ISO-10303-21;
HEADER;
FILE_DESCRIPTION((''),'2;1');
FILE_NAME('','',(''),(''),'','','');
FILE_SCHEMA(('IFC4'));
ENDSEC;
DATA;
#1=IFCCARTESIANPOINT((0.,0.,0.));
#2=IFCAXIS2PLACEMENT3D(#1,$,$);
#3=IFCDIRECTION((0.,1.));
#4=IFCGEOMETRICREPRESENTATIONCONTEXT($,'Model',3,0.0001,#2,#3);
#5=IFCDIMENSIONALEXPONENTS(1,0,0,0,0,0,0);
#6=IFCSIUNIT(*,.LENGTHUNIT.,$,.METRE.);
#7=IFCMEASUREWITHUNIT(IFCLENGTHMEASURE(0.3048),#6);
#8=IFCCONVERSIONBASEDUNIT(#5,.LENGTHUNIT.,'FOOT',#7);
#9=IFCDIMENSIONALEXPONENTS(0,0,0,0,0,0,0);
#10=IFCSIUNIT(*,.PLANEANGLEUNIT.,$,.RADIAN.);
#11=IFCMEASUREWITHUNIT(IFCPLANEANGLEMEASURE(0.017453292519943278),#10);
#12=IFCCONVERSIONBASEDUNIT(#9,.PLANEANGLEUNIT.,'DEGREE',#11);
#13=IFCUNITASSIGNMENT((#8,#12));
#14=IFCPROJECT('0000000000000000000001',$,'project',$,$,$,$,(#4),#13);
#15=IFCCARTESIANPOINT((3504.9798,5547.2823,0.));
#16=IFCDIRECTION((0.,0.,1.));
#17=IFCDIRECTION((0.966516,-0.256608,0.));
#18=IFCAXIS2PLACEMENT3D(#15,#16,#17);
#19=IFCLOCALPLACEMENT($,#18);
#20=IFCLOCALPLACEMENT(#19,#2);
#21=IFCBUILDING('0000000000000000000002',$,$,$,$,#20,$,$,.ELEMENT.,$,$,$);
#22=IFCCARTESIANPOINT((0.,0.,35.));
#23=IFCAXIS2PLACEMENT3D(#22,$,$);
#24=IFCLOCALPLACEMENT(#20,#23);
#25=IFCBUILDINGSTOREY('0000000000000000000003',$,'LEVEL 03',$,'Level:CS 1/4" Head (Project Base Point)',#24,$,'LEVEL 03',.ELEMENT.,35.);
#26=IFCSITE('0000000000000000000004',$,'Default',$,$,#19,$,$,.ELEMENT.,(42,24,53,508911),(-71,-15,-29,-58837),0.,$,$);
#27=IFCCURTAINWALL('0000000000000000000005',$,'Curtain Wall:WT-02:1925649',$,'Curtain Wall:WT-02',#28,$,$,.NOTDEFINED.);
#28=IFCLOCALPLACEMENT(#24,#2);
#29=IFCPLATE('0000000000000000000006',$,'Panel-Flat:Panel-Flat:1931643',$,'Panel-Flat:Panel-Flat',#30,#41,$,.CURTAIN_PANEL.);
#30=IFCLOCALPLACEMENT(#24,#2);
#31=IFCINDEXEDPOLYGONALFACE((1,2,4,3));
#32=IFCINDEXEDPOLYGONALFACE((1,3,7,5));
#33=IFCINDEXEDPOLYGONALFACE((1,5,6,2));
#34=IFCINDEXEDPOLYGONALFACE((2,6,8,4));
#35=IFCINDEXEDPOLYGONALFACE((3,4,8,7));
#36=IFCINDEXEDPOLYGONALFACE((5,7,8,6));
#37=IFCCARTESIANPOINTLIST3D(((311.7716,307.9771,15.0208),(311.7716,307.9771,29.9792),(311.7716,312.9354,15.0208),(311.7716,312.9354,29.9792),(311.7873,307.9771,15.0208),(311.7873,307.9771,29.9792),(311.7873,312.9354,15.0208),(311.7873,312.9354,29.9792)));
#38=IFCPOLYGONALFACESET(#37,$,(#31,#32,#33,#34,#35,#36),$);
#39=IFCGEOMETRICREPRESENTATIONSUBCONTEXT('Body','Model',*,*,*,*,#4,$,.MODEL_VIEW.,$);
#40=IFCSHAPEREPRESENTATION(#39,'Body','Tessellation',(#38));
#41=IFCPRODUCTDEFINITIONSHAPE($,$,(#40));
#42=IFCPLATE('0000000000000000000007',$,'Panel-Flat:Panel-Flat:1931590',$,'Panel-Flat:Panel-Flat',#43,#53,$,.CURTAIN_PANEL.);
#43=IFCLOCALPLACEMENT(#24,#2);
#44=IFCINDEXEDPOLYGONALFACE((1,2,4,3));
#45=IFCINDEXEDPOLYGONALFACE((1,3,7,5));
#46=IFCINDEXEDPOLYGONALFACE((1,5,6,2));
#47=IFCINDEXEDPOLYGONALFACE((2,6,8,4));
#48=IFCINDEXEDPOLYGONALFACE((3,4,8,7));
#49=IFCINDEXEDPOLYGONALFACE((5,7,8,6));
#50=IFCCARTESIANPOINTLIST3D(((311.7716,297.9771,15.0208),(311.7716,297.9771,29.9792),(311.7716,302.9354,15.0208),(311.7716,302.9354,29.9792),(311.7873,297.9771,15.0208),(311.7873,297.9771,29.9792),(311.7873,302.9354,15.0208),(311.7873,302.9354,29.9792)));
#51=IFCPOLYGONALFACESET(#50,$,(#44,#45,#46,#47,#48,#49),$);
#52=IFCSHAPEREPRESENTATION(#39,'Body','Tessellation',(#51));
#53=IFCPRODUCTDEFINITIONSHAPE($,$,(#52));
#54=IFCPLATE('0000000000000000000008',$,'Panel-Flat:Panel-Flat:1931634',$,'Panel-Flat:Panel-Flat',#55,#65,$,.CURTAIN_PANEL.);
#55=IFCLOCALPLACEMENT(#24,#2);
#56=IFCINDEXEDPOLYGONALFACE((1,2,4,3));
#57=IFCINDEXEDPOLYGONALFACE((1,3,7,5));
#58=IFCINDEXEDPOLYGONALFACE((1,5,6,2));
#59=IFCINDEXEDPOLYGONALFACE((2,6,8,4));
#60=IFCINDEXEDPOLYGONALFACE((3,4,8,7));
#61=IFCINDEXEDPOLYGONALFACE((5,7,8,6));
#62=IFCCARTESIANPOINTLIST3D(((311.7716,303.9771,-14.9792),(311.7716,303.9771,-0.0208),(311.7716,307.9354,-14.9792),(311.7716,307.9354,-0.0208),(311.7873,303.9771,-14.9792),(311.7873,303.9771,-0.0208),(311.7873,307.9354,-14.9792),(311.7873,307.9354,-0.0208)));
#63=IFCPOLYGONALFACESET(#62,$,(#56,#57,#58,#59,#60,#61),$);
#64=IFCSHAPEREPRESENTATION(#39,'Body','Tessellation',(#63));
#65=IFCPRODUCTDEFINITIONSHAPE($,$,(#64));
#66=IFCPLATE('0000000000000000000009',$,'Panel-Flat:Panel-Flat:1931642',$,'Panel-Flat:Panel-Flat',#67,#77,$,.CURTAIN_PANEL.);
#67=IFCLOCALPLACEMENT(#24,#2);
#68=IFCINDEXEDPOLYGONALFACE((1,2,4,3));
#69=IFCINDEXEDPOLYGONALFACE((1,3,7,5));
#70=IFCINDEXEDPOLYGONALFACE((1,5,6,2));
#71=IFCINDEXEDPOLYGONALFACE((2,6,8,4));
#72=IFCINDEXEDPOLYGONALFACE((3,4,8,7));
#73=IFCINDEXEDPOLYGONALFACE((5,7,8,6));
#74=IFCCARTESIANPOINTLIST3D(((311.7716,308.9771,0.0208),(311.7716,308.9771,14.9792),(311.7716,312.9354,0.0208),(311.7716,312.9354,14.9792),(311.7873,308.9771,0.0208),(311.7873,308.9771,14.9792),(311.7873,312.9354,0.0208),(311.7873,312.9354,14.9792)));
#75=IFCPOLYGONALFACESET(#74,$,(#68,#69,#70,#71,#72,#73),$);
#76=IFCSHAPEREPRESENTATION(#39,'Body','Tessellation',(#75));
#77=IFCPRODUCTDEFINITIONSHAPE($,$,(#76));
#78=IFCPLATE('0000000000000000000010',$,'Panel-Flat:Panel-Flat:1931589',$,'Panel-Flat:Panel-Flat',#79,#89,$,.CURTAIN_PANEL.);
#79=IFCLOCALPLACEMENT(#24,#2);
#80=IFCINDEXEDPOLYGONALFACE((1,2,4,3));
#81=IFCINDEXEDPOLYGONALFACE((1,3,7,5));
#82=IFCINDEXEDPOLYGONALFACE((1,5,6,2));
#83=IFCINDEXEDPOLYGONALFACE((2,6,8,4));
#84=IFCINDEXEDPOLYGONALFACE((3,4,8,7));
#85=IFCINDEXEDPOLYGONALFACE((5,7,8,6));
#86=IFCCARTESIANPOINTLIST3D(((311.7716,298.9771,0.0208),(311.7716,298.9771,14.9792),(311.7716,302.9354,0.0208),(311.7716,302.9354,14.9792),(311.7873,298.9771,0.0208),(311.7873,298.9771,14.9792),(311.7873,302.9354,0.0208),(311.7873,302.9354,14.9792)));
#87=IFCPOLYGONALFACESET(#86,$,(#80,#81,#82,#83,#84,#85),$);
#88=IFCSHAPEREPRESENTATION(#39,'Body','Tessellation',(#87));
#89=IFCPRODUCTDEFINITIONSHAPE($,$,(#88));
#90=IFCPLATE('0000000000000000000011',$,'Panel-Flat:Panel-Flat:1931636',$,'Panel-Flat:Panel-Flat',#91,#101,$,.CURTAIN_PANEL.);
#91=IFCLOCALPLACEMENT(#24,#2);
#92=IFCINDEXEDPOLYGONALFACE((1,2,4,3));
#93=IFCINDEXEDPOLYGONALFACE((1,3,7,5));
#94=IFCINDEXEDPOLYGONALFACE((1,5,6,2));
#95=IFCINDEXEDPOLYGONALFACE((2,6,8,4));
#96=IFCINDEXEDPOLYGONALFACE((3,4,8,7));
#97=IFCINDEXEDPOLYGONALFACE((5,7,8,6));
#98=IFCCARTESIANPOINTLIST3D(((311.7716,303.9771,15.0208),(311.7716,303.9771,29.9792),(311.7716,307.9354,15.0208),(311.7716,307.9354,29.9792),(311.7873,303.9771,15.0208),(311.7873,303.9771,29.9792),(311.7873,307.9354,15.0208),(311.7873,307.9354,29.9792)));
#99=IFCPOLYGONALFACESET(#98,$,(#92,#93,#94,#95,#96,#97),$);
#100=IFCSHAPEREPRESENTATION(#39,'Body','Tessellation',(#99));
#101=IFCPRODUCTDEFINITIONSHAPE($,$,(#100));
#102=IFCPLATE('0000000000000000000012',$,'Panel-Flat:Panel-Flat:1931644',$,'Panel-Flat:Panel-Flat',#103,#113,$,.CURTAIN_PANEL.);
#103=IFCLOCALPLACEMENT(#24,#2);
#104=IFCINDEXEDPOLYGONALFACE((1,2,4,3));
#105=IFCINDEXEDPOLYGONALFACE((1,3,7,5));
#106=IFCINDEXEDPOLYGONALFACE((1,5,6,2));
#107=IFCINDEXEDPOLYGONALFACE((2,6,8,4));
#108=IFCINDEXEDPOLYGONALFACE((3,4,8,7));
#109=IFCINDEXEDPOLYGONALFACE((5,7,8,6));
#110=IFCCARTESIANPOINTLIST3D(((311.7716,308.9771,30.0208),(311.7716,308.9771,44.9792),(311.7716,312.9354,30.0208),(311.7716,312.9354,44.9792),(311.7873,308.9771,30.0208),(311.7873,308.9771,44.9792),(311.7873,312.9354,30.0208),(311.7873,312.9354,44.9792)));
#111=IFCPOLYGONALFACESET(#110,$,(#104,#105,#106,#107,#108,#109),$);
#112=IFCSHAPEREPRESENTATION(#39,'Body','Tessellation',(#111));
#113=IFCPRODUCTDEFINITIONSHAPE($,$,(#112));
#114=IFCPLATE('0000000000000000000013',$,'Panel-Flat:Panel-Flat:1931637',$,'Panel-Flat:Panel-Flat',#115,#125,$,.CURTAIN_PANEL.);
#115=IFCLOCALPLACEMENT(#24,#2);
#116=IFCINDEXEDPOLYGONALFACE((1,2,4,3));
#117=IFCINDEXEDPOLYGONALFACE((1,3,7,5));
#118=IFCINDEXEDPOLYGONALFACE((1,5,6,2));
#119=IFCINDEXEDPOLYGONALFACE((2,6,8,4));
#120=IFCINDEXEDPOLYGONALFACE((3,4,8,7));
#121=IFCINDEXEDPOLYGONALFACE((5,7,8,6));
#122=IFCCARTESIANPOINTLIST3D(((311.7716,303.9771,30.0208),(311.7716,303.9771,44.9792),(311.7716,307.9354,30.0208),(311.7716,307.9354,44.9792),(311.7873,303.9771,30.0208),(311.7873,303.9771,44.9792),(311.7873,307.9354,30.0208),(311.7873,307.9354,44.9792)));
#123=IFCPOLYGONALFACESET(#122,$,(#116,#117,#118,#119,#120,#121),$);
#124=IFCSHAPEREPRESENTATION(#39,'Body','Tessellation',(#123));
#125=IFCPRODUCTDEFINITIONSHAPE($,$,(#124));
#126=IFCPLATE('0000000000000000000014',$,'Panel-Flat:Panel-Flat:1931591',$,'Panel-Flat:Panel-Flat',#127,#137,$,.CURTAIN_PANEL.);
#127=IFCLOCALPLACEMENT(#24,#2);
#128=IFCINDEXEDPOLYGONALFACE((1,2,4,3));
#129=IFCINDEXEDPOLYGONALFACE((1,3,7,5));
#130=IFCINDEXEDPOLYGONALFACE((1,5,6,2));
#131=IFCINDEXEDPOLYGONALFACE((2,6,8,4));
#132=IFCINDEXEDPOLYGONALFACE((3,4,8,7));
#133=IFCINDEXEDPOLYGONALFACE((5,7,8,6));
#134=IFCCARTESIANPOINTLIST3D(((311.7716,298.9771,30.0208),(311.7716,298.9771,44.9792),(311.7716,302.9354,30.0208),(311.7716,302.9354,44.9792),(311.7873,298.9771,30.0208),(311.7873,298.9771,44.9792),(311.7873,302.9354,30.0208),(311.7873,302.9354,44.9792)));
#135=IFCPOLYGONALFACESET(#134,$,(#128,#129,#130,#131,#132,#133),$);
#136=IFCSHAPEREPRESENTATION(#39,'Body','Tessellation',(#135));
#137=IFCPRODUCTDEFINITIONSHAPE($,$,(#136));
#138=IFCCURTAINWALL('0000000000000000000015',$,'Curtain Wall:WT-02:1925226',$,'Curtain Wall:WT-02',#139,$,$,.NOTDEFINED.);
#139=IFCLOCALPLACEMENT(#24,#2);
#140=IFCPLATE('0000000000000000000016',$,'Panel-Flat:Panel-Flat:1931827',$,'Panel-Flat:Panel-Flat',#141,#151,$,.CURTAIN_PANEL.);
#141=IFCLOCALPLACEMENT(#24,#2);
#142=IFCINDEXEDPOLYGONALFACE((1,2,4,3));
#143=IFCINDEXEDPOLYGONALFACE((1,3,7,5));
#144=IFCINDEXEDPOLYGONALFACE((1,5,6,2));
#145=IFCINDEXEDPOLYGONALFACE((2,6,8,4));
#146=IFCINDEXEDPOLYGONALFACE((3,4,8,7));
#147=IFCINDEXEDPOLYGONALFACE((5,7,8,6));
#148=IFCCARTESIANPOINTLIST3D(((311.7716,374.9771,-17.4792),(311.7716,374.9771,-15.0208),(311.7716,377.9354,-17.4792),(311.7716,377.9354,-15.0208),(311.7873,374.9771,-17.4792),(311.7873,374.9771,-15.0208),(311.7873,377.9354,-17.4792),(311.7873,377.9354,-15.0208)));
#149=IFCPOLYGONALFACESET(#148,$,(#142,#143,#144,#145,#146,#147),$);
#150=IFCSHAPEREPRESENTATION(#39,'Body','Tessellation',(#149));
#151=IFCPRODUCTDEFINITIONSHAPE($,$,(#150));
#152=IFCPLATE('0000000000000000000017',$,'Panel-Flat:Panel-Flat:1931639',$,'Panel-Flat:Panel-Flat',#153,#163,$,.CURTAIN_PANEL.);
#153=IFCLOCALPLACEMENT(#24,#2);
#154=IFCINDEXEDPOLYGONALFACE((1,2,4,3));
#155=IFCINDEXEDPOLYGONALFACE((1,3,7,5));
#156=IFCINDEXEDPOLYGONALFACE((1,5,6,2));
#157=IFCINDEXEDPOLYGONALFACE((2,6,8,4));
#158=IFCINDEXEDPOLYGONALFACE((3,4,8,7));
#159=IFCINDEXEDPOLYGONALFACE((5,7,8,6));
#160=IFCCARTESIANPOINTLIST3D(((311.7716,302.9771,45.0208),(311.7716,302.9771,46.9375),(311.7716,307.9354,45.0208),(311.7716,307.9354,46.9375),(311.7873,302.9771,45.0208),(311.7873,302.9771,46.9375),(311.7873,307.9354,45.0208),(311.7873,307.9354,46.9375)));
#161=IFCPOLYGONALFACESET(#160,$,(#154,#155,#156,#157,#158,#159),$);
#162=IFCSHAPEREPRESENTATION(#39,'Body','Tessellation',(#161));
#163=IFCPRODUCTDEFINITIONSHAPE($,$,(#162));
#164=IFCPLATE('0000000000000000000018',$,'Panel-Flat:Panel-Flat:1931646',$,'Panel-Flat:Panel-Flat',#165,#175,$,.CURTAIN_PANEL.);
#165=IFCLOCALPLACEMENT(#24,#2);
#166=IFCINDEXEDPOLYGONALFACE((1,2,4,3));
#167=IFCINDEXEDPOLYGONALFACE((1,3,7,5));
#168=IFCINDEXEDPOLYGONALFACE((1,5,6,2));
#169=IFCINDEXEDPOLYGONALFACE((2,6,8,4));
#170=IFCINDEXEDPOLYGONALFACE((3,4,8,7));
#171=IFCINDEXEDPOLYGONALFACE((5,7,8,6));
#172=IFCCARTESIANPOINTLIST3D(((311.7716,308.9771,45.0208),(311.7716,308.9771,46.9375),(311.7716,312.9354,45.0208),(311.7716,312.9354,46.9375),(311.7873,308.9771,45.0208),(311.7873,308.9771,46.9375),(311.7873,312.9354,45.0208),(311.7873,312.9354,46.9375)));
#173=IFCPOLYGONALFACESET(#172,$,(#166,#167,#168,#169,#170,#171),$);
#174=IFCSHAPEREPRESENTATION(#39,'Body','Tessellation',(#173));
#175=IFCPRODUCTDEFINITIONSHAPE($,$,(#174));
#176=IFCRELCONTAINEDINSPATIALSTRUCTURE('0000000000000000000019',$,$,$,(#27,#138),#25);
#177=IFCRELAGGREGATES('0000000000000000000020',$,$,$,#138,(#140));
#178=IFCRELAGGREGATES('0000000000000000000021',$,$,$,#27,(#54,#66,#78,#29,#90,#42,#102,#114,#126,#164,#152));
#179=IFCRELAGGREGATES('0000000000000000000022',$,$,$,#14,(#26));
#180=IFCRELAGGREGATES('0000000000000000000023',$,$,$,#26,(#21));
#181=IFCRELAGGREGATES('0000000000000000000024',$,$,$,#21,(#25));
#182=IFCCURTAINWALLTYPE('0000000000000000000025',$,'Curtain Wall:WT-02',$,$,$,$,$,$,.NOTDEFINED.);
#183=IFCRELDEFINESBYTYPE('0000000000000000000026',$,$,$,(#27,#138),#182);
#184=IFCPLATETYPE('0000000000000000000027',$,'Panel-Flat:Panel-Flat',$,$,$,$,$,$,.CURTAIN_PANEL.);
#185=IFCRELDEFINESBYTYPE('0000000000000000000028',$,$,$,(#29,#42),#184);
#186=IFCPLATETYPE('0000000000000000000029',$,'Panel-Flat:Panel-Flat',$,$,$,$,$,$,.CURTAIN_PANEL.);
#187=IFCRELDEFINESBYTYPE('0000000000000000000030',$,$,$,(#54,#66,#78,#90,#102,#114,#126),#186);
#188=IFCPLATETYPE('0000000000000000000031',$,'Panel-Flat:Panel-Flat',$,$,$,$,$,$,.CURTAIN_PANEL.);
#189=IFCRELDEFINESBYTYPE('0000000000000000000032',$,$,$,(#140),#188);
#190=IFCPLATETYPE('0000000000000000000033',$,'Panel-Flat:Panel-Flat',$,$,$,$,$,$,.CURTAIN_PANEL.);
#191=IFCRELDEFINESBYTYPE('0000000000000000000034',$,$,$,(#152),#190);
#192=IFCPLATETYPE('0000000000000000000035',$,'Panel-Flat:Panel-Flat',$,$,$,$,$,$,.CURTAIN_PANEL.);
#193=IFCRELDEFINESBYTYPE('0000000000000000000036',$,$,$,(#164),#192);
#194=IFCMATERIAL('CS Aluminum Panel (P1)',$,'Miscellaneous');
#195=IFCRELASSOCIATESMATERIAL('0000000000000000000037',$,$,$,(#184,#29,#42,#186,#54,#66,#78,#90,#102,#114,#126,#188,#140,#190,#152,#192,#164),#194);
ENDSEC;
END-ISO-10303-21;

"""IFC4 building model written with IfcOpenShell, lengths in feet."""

from ifc_helpers import new_model, entity, si_unit, converted_unit, direction, frame, origin, place, context, subcontext, project, spatial, indexed_curve, outline, extrude, source, transform, mapped, material, type_object, type_shapes, element, aggregate, save


model = new_model("IFC4")

# Units and contexts
model_context = context("Model", 3, precision=0.0001, world=origin(), true_north=direction((0.0, 1.0)))
body_context = subcontext(model_context, "Body", "Model", "MODEL_VIEW")
ifc_project = project(units=[converted_unit("LENGTHUNIT", "FOOT", entity("IfcLengthMeasure", 0.3048), si_unit("LENGTHUNIT", "METRE"), dimensions=[1, 0, 0, 0, 0, 0, 0]), converted_unit("PLANEANGLEUNIT", "DEGREE", entity("IfcPlaneAngleMeasure", 0.017453292519943278), si_unit("PLANEANGLEUNIT", "RADIAN"), dimensions=[0, 0, 0, 0, 0, 0, 0])], contexts=[model_context])

# Site, building, storey
site_placement = place(None, frame((3504.9798, 5547.2823, 0.0), z_axis=(0.0, 0.0, 1.0), x_axis=(0.966516, -0.256608, 0.0)))
site = spatial("IfcSite", under=ifc_project, at=site_placement, Name="Default", CompositionType="ELEMENT", RefLatitude=(42, 24, 53, 508911), RefLongitude=(-71, -15, -29, -58837), RefElevation=0.0)
building_placement = place(site_placement, origin())
building = spatial("IfcBuilding", under=site, at=building_placement, CompositionType="ELEMENT")
storey_placement = place(building_placement, frame((0.0, 0.0, 35.0)))
storey = spatial("IfcBuildingStorey", under=building, at=storey_placement, Name="LEVEL 03", ObjectType="Level:CS 1/4\" Head (Project Base Point)", LongName="LEVEL 03", CompositionType="ELEMENT", Elevation=35.0)

# Curtain walls, plates
curtain_wall_type = type_object("IfcCurtainWallType", Name="Curtain Wall:WT-02", PredefinedType="NOTDEFINED")
curtain_wall_1_placement = place(storey_placement, frame((0.0, 0.0, -35.0)))
curtain_wall_1 = element("IfcCurtainWall", 1, at=curtain_wall_1_placement, inside=storey, type_object=curtain_wall_type, Name="Curtain Wall:WT-02:1925649", ObjectType="Curtain Wall:WT-02", PredefinedType="NOTDEFINED")
ifc_material_1 = material(Name="CS Aluminum Panel (P1)", Category="Miscellaneous")
plate_type_1 = type_object("IfcPlateType", Name="Panel-Flat:Panel-Flat", PredefinedType="CURTAIN_PANEL", material=ifc_material_1)
shared_shape_1 = source(origin(), body_context, "Body", "SweptSolid", [
    extrude(outline(indexed_curve([(-0.0078, -2.4792), (0.0078, -2.4792), (0.0078, 2.4792), (-0.0078, 2.4792), (-0.0078, -2.4792)], self_intersect=False)), frame((2.4792, 0.0078, 0.0), z_axis=(0.0, 0.0, 1.0), x_axis=(0.0, -1.0, 0.0)), (0.0, 0.0, 1.0), 14.9583),
])
type_shapes(plate_type_1, [shared_shape_1])
plate_1_placement = place(curtain_wall_1_placement, frame((311.7716, 312.9354, 50.0208), z_axis=(0.0, 0.0, 1.0), x_axis=(0.0, -1.0, 0.0)))
plate_1 = element("IfcPlate", 2, at=plate_1_placement, type_object=plate_type_1, material=ifc_material_1, Name="Panel-Flat:Panel-Flat:1931643", ObjectType="Panel-Flat:Panel-Flat", PredefinedType="CURTAIN_PANEL", context=body_context, shape_type="MappedRepresentation", body=[
    mapped(shared_shape_1, transform((0.0, 0.0, 0.0), scale=1.0)),
])
plate_2_placement = place(curtain_wall_1_placement, frame((311.7716, 302.9354, 50.0208), z_axis=(0.0, 0.0, 1.0), x_axis=(0.0, -1.0, 0.0)))
plate_2 = element("IfcPlate", 3, at=plate_2_placement, type_object=plate_type_1, material=ifc_material_1, Name="Panel-Flat:Panel-Flat:1931590", ObjectType="Panel-Flat:Panel-Flat", PredefinedType="CURTAIN_PANEL", context=body_context, shape_type="MappedRepresentation", body=[
    mapped(shared_shape_1, transform((0.0, 0.0, 0.0), scale=1.0)),
])
plate_type_2 = type_object("IfcPlateType", Name="Panel-Flat:Panel-Flat", PredefinedType="CURTAIN_PANEL", material=ifc_material_1)
shared_shape_2 = source(origin(), body_context, "Body", "SweptSolid", [
    extrude(outline(indexed_curve([(-0.0078, -1.9792), (0.0078, -1.9792), (0.0078, 1.9792), (-0.0078, 1.9792), (-0.0078, -1.9792)], self_intersect=False)), frame((1.9792, 0.0078, 0.0), z_axis=(0.0, 0.0, 1.0), x_axis=(0.0, -1.0, 0.0)), (0.0, 0.0, 1.0), 14.9583),
])
type_shapes(plate_type_2, [shared_shape_2])
plate_3_placement = place(curtain_wall_1_placement, frame((311.7716, 307.9354, 20.0208), z_axis=(0.0, 0.0, 1.0), x_axis=(0.0, -1.0, 0.0)))
plate_3 = element("IfcPlate", 4, at=plate_3_placement, type_object=plate_type_2, material=ifc_material_1, Name="Panel-Flat:Panel-Flat:1931634", ObjectType="Panel-Flat:Panel-Flat", PredefinedType="CURTAIN_PANEL", context=body_context, shape_type="MappedRepresentation", body=[
    mapped(shared_shape_2, transform((0.0, 0.0, 0.0), scale=1.0)),
])
plate_4_placement = place(curtain_wall_1_placement, frame((311.7716, 312.9354, 35.0208), z_axis=(0.0, 0.0, 1.0), x_axis=(0.0, -1.0, 0.0)))
plate_4 = element("IfcPlate", 5, at=plate_4_placement, type_object=plate_type_2, material=ifc_material_1, Name="Panel-Flat:Panel-Flat:1931642", ObjectType="Panel-Flat:Panel-Flat", PredefinedType="CURTAIN_PANEL", context=body_context, shape_type="MappedRepresentation", body=[
    mapped(shared_shape_2, transform((0.0, 0.0, 0.0), scale=1.0)),
])
plate_5_placement = place(curtain_wall_1_placement, frame((311.7716, 302.9354, 35.0208), z_axis=(0.0, 0.0, 1.0), x_axis=(0.0, -1.0, 0.0)))
plate_5 = element("IfcPlate", 6, at=plate_5_placement, type_object=plate_type_2, material=ifc_material_1, Name="Panel-Flat:Panel-Flat:1931589", ObjectType="Panel-Flat:Panel-Flat", PredefinedType="CURTAIN_PANEL", context=body_context, shape_type="MappedRepresentation", body=[
    mapped(shared_shape_2, transform((0.0, 0.0, 0.0), scale=1.0)),
])
plate_6_placement = place(curtain_wall_1_placement, frame((311.7716, 307.9354, 50.0208), z_axis=(0.0, 0.0, 1.0), x_axis=(0.0, -1.0, 0.0)))
plate_6 = element("IfcPlate", 7, at=plate_6_placement, type_object=plate_type_2, material=ifc_material_1, Name="Panel-Flat:Panel-Flat:1931636", ObjectType="Panel-Flat:Panel-Flat", PredefinedType="CURTAIN_PANEL", context=body_context, shape_type="MappedRepresentation", body=[
    mapped(shared_shape_2, transform((0.0, 0.0, 0.0), scale=1.0)),
])
plate_7_placement = place(curtain_wall_1_placement, frame((311.7716, 312.9354, 65.0208), z_axis=(0.0, 0.0, 1.0), x_axis=(0.0, -1.0, 0.0)))
plate_7 = element("IfcPlate", 8, at=plate_7_placement, type_object=plate_type_2, material=ifc_material_1, Name="Panel-Flat:Panel-Flat:1931644", ObjectType="Panel-Flat:Panel-Flat", PredefinedType="CURTAIN_PANEL", context=body_context, shape_type="MappedRepresentation", body=[
    mapped(shared_shape_2, transform((0.0, 0.0, 0.0), scale=1.0)),
])
plate_8_placement = place(curtain_wall_1_placement, frame((311.7716, 307.9354, 65.0208), z_axis=(0.0, 0.0, 1.0), x_axis=(0.0, -1.0, 0.0)))
plate_8 = element("IfcPlate", 9, at=plate_8_placement, type_object=plate_type_2, material=ifc_material_1, Name="Panel-Flat:Panel-Flat:1931637", ObjectType="Panel-Flat:Panel-Flat", PredefinedType="CURTAIN_PANEL", context=body_context, shape_type="MappedRepresentation", body=[
    mapped(shared_shape_2, transform((0.0, 0.0, 0.0), scale=1.0)),
])
plate_9_placement = place(curtain_wall_1_placement, frame((311.7716, 302.9354, 65.0208), z_axis=(0.0, 0.0, 1.0), x_axis=(0.0, -1.0, 0.0)))
plate_9 = element("IfcPlate", 10, at=plate_9_placement, type_object=plate_type_2, material=ifc_material_1, Name="Panel-Flat:Panel-Flat:1931591", ObjectType="Panel-Flat:Panel-Flat", PredefinedType="CURTAIN_PANEL", context=body_context, shape_type="MappedRepresentation", body=[
    mapped(shared_shape_2, transform((0.0, 0.0, 0.0), scale=1.0)),
])
curtain_wall_2_placement = place(storey_placement, frame((0.0, 0.0, -35.0)))
curtain_wall_2 = element("IfcCurtainWall", 11, at=curtain_wall_2_placement, inside=storey, type_object=curtain_wall_type, Name="Curtain Wall:WT-02:1925226", ObjectType="Curtain Wall:WT-02", PredefinedType="NOTDEFINED")
plate_type_3 = type_object("IfcPlateType", Name="Panel-Flat:Panel-Flat", PredefinedType="CURTAIN_PANEL", material=ifc_material_1)
shared_shape_3 = source(origin(), body_context, "Body", "SweptSolid", [
    extrude(outline(indexed_curve([(-0.0078, -1.4792), (0.0078, -1.4792), (0.0078, 1.4792), (-0.0078, 1.4792), (-0.0078, -1.4792)], self_intersect=False)), frame((1.4792, 0.0078, 0.0), z_axis=(0.0, 0.0, 1.0), x_axis=(0.0, -1.0, 0.0)), (0.0, 0.0, 1.0), 2.4583),
])
type_shapes(plate_type_3, [shared_shape_3])
plate_10_placement = place(curtain_wall_2_placement, frame((311.7716, 377.9354, 17.5208), z_axis=(0.0, 0.0, 1.0), x_axis=(0.0, -1.0, 0.0)))
plate_10 = element("IfcPlate", 12, at=plate_10_placement, type_object=plate_type_3, material=ifc_material_1, Name="Panel-Flat:Panel-Flat:1931827", ObjectType="Panel-Flat:Panel-Flat", PredefinedType="CURTAIN_PANEL", context=body_context, shape_type="MappedRepresentation", body=[
    mapped(shared_shape_3, transform((0.0, 0.0, 0.0), scale=1.0)),
])
aggregate(curtain_wall_2, [plate_10])

# Plates
plate_type_4 = type_object("IfcPlateType", Name="Panel-Flat:Panel-Flat", PredefinedType="CURTAIN_PANEL", material=ifc_material_1)
shared_shape_4 = source(origin(), body_context, "Body", "SweptSolid", [
    extrude(outline(indexed_curve([(-0.0078, -2.4792), (0.0078, -2.4792), (0.0078, 2.4792), (-0.0078, 2.4792), (-0.0078, -2.4792)], self_intersect=False)), frame((2.4792, 0.0078, 0.0), z_axis=(0.0, 0.0, 1.0), x_axis=(0.0, -1.0, 0.0)), (0.0, 0.0, 1.0), 1.9167),
])
type_shapes(plate_type_4, [shared_shape_4])
plate_11_placement = place(curtain_wall_1_placement, frame((311.7716, 307.9354, 80.0208), z_axis=(0.0, 0.0, 1.0), x_axis=(0.0, -1.0, 0.0)))
plate_11 = element("IfcPlate", 13, at=plate_11_placement, type_object=plate_type_4, material=ifc_material_1, Name="Panel-Flat:Panel-Flat:1931639", ObjectType="Panel-Flat:Panel-Flat", PredefinedType="CURTAIN_PANEL", context=body_context, shape_type="MappedRepresentation", body=[
    mapped(shared_shape_4, transform((0.0, 0.0, 0.0), scale=1.0)),
])
plate_type_5 = type_object("IfcPlateType", Name="Panel-Flat:Panel-Flat", PredefinedType="CURTAIN_PANEL", material=ifc_material_1)
shared_shape_5 = source(origin(), body_context, "Body", "SweptSolid", [
    extrude(outline(indexed_curve([(-0.0078, -1.9792), (0.0078, -1.9792), (0.0078, 1.9792), (-0.0078, 1.9792), (-0.0078, -1.9792)], self_intersect=False)), frame((1.9792, 0.0078, 0.0), z_axis=(0.0, 0.0, 1.0), x_axis=(0.0, -1.0, 0.0)), (0.0, 0.0, 1.0), 1.9167),
])
type_shapes(plate_type_5, [shared_shape_5])
plate_12_placement = place(curtain_wall_1_placement, frame((311.7716, 312.9354, 80.0208), z_axis=(0.0, 0.0, 1.0), x_axis=(0.0, -1.0, 0.0)))
plate_12 = element("IfcPlate", 14, at=plate_12_placement, type_object=plate_type_5, material=ifc_material_1, Name="Panel-Flat:Panel-Flat:1931646", ObjectType="Panel-Flat:Panel-Flat", PredefinedType="CURTAIN_PANEL", context=body_context, shape_type="MappedRepresentation", body=[
    mapped(shared_shape_5, transform((0.0, 0.0, 0.0), scale=1.0)),
])
aggregate(curtain_wall_1, [plate_3, plate_4, plate_5, plate_1, plate_6, plate_2, plate_7, plate_8, plate_9, plate_12, plate_11])

save(model, "model.ifc")
